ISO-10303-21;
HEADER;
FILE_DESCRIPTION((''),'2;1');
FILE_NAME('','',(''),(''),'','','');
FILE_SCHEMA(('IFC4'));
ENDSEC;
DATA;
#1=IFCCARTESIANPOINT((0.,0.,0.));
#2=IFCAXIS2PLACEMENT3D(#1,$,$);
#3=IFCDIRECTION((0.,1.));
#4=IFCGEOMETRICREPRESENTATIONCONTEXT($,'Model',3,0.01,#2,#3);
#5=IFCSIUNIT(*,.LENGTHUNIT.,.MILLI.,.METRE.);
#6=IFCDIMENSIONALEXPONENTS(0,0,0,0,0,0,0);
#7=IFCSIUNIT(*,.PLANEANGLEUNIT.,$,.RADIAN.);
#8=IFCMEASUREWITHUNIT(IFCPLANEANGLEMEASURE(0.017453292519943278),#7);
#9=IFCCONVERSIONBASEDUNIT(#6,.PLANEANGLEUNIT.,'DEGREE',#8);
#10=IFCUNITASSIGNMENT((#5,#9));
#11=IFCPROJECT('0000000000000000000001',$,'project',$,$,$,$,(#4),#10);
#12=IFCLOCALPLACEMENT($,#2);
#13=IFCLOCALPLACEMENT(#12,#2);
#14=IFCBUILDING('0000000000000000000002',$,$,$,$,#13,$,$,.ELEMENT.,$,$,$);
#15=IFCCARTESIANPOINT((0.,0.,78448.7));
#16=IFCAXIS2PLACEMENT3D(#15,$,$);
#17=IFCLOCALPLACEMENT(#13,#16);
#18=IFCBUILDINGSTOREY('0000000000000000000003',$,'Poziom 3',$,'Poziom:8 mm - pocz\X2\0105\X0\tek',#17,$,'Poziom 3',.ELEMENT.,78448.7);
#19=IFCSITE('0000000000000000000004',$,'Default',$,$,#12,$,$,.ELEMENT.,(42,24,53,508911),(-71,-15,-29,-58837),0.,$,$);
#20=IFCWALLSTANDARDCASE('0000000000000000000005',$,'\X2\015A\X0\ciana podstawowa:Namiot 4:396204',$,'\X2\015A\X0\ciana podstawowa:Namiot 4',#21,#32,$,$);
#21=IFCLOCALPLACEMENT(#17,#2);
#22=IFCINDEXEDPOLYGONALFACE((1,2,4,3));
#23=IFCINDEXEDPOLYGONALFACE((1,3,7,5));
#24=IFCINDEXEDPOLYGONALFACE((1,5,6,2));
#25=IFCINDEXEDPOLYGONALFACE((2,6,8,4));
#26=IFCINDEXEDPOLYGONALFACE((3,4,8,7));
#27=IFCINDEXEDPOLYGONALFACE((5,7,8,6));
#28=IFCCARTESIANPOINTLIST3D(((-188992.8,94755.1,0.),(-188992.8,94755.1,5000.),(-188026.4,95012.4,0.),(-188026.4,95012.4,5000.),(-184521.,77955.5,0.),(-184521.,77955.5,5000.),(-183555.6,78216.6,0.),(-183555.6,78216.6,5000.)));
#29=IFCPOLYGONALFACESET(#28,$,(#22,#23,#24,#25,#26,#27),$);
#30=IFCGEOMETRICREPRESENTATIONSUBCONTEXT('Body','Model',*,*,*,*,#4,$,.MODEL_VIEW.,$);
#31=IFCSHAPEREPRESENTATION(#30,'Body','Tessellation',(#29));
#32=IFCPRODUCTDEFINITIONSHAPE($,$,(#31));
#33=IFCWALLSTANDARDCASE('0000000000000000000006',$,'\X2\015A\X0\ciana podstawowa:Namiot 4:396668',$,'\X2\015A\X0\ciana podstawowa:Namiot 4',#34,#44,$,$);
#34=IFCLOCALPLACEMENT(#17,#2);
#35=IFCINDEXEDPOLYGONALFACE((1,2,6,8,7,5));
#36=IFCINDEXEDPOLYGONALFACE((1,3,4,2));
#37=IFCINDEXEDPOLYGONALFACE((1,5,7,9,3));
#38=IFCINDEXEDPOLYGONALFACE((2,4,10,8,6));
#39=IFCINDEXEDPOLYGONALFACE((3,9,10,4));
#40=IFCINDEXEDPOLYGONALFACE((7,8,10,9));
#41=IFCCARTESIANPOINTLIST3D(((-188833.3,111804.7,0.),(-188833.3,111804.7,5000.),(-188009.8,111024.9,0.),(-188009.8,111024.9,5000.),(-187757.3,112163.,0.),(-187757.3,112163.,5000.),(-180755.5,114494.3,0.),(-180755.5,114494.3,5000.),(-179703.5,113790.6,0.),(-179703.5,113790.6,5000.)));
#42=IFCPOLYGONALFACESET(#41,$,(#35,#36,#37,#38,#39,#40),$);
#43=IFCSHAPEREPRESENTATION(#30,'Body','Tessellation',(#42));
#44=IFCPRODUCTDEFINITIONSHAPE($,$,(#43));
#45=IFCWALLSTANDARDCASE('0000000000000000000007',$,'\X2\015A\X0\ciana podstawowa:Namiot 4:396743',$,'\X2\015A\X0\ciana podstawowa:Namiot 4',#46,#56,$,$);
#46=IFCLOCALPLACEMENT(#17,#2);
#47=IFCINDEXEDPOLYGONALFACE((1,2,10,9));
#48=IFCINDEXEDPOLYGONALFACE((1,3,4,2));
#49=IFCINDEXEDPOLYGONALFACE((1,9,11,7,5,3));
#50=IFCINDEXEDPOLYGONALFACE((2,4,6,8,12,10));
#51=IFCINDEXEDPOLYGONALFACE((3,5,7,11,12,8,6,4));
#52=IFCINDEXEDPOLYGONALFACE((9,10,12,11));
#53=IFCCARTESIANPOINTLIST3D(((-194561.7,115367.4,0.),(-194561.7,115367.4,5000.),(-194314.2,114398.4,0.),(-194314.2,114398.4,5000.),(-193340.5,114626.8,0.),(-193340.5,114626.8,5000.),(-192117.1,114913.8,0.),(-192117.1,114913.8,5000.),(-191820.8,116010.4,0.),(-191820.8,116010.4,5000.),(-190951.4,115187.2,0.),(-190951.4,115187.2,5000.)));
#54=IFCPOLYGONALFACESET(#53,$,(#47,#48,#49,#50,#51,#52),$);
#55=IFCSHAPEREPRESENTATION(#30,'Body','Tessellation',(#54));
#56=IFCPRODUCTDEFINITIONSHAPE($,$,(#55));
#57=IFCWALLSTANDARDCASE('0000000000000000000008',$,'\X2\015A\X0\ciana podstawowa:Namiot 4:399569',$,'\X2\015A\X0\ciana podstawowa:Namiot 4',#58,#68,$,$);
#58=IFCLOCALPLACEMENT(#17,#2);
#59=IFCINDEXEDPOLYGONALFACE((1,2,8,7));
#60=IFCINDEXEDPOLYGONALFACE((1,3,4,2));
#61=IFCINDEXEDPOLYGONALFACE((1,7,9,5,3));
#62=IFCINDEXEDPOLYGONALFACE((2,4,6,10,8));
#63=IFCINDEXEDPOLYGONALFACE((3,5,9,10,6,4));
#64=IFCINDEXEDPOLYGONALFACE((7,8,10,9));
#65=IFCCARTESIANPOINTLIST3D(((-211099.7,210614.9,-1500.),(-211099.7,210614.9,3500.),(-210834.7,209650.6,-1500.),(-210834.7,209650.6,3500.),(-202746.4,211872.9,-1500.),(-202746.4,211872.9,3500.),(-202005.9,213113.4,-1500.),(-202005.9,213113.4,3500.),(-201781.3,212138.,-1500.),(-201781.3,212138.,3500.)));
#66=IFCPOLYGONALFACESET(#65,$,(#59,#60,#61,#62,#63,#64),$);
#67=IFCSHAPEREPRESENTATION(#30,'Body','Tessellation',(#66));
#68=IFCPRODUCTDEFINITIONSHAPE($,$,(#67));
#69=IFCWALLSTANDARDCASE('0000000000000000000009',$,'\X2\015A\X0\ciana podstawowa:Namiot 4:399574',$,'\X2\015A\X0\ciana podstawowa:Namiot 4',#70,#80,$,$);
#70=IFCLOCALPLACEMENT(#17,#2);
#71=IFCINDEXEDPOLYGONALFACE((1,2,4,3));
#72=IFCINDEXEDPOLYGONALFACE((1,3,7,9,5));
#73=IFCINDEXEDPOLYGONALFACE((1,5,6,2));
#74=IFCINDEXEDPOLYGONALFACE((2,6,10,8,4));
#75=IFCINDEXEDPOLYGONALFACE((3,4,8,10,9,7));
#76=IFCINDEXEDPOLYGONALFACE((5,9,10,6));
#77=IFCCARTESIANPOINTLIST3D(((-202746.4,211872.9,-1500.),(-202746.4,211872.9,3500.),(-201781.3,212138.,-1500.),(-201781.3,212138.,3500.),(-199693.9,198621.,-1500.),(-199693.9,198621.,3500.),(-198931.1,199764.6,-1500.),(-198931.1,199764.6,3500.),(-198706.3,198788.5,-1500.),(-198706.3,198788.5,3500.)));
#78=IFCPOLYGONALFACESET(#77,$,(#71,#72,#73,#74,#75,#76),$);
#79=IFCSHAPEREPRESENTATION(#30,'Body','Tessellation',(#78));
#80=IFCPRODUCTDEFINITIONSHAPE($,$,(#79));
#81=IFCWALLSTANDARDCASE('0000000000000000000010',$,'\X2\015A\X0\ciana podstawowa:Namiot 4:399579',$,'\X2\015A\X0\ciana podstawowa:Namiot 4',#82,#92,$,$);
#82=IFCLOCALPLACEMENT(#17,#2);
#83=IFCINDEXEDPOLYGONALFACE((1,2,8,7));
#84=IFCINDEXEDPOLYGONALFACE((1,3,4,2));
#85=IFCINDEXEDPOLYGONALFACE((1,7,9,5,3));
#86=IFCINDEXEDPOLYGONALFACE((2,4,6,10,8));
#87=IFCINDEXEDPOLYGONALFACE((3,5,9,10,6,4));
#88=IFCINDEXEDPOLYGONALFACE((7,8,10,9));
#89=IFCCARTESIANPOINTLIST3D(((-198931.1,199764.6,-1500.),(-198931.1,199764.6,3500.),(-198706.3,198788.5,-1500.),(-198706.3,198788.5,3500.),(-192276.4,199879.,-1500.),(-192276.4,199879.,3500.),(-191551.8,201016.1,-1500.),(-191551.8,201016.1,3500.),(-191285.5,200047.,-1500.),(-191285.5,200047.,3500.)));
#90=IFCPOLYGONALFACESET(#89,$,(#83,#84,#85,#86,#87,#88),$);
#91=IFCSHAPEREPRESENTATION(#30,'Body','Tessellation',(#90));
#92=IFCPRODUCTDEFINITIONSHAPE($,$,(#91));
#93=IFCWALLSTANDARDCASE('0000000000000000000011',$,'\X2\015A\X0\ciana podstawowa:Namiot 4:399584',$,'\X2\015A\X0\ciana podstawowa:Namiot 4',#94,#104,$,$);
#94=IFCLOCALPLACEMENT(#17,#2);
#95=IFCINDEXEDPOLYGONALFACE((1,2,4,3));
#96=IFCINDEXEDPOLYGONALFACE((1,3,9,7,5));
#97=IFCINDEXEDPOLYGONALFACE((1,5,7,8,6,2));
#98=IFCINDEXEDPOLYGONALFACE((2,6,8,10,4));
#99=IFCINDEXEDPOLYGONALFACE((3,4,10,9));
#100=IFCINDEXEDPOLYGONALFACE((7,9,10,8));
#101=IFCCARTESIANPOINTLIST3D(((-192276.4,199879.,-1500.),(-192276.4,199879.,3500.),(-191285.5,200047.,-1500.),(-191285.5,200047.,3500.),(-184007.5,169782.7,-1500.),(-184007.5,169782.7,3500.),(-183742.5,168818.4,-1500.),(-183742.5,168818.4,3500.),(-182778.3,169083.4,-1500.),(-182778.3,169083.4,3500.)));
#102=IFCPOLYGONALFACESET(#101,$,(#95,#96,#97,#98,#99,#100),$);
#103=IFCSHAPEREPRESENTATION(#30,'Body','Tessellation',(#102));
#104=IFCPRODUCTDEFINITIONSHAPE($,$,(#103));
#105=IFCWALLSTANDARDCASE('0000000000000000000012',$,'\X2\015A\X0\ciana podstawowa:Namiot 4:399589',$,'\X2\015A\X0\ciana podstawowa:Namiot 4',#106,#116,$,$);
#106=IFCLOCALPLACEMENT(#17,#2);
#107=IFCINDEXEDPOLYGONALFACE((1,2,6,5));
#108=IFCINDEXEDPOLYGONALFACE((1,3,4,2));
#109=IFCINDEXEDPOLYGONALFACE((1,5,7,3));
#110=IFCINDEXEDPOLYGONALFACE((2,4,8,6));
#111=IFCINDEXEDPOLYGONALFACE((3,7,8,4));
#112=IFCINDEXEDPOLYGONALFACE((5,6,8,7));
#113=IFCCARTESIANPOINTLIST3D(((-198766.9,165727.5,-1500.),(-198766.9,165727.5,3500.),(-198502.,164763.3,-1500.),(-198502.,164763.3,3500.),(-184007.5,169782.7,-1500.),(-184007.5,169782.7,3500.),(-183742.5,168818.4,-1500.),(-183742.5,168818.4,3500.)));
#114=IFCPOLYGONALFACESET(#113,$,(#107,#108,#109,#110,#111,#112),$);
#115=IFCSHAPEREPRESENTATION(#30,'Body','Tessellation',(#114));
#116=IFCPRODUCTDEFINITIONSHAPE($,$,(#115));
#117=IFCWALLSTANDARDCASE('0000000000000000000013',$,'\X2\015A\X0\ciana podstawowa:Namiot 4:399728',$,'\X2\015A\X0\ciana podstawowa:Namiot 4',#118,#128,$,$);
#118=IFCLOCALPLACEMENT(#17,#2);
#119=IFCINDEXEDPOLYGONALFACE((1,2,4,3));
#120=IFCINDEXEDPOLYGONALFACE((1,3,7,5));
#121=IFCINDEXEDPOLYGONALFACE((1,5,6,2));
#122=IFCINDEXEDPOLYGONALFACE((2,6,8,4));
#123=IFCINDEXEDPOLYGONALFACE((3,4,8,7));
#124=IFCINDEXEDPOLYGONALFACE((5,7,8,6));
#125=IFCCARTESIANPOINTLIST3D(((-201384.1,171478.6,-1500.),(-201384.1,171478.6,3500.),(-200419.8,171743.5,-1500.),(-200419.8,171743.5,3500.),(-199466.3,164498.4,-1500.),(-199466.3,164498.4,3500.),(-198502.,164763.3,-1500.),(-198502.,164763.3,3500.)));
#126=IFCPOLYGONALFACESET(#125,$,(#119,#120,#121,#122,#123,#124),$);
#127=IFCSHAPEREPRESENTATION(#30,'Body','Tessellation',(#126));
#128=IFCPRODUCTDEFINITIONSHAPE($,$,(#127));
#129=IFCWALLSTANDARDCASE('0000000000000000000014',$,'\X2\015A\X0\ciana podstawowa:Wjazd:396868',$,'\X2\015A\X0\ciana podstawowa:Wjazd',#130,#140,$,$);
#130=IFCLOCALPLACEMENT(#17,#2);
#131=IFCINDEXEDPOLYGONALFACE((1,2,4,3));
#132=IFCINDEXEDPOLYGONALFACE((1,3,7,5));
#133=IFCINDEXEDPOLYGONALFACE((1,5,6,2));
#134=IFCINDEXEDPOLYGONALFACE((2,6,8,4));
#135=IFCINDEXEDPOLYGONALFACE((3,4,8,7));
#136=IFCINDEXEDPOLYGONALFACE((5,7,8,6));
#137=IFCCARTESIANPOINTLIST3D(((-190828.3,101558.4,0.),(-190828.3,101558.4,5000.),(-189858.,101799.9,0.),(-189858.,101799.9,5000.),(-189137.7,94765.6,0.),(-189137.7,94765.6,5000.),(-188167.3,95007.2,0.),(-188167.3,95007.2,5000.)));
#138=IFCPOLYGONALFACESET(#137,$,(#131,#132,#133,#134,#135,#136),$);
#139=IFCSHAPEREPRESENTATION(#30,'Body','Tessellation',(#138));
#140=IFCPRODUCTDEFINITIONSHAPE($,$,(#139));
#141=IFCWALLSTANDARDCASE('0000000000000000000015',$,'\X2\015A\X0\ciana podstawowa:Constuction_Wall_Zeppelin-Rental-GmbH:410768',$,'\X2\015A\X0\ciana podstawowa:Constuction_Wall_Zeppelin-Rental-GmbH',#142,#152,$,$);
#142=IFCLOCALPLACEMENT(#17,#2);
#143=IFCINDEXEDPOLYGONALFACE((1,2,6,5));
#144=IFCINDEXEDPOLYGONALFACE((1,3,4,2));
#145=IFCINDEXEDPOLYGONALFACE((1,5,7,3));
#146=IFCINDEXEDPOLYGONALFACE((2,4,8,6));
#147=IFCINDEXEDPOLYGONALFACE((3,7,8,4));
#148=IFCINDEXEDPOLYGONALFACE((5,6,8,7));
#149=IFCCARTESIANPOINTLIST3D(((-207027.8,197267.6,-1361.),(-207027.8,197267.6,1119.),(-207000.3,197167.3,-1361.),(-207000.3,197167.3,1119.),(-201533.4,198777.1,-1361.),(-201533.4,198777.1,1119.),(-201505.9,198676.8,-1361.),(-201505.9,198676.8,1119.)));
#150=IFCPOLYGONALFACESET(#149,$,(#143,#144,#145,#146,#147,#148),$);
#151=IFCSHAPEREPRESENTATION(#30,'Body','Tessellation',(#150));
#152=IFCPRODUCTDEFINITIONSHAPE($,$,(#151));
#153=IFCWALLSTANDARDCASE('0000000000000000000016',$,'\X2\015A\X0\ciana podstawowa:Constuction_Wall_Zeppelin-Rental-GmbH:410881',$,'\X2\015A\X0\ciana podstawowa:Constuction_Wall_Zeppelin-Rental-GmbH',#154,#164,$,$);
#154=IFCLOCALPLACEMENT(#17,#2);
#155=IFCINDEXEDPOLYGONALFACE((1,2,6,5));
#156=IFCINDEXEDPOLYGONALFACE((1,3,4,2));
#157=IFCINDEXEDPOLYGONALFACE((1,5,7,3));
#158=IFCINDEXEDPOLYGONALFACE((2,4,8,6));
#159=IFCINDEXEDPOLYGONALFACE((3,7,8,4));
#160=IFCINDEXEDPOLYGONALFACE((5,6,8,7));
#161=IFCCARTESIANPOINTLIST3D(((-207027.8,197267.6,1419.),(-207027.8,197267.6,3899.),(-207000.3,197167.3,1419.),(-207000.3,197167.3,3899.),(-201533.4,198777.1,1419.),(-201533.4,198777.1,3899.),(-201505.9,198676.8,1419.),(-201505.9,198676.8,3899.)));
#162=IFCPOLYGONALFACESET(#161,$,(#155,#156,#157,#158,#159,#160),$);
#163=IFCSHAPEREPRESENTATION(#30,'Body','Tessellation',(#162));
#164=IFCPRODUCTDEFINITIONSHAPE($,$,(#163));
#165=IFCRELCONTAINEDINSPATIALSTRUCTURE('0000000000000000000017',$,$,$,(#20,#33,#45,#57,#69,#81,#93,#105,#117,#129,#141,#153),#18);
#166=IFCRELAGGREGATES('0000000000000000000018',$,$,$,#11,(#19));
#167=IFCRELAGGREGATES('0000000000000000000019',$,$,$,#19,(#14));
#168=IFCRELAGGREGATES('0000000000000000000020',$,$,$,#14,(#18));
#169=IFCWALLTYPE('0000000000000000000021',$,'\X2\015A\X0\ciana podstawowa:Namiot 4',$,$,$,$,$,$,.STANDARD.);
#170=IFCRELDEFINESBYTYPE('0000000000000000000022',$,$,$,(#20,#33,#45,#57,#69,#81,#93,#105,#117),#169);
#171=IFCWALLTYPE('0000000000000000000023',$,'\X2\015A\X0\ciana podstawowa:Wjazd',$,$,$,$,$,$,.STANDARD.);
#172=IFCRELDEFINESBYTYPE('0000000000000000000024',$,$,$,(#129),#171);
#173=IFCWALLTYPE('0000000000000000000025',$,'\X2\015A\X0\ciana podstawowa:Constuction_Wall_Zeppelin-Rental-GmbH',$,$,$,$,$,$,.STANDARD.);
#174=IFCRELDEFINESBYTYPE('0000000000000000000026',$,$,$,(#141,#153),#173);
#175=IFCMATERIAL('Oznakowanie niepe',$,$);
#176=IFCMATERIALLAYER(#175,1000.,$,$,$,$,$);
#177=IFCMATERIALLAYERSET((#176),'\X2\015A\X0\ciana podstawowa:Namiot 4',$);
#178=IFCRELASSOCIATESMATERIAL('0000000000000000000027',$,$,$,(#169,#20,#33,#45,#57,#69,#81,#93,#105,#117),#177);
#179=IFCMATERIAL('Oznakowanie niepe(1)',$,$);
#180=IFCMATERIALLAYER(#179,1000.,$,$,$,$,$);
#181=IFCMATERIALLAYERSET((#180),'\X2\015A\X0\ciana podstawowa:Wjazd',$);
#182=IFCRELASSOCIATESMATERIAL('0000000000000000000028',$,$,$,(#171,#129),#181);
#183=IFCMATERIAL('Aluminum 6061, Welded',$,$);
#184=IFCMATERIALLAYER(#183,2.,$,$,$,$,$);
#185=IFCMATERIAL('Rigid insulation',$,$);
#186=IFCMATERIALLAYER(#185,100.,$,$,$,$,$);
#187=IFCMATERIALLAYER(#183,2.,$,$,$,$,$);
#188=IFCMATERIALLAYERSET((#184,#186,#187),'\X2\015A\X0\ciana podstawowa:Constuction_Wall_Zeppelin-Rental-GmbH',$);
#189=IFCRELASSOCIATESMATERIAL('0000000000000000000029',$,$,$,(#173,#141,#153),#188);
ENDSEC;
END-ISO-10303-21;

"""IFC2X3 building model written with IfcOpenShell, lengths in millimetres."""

from ifc_helpers import new_model, entity, si_unit, converted_unit, direction, frame, frame_2d, origin, place, context, subcontext, project, spatial, polyline, rectangle, outline, extrude, material, layer, layer_set, layer_usage, type_object, element, save


model = new_model("IFC2X3")

# Units and contexts
model_context = context("Model", 3, precision=0.01, world=origin(), true_north=direction((0.0, 1.0)))
body_context = subcontext(model_context, "Body", "Model", "MODEL_VIEW")
ifc_project = project(units=[si_unit("LENGTHUNIT", "METRE", prefix="MILLI"), converted_unit("PLANEANGLEUNIT", "DEGREE", entity("IfcPlaneAngleMeasure", 0.017453292519943278), si_unit("PLANEANGLEUNIT", "RADIAN"), dimensions=[0, 0, 0, 0, 0, 0, 0])], contexts=[model_context])

# Site, building, storey
site_placement = place(None, origin())
site = spatial("IfcSite", under=ifc_project, at=site_placement, Name="Default", CompositionType="ELEMENT", RefLatitude=(42, 24, 53, 508911), RefLongitude=(-71, -15, -29, -58837), RefElevation=0.0)
building_placement = place(site_placement, origin())
building = spatial("IfcBuilding", under=site, at=building_placement, CompositionType="ELEMENT")
storey_placement = place(building_placement, frame((0.0, 0.0, 78448.7)))
storey = spatial("IfcBuildingStorey", under=building, at=storey_placement, Name="Poziom 3", ObjectType="Poziom:8 mm - początek", LongName="Poziom 3", CompositionType="ELEMENT", Elevation=78448.7)

# Walls
ifc_material_1 = material(Name="Oznakowanie niepe")
ifc_layer_1 = layer(ifc_material_1, 1000.0)
ifc_layer_set_1 = layer_set([ifc_layer_1], Name="Ściana podstawowa:Namiot 4")
ifc_layer_usage_1 = layer_usage(ifc_layer_set_1, "AXIS2", "NEGATIVE", 500.0)
wall_type_1 = type_object("IfcWallType", Name="Ściana podstawowa:Namiot 4", PredefinedType="STANDARD", material=ifc_layer_set_1)
wall_1_placement = place(storey_placement, frame((-188509.6, 94883.7, 0.0), z_axis=(0.0, 0.0, 1.0), x_axis=(0.257227, -0.966351, 0.0)))
element("IfcWallStandardCase", 1, at=wall_1_placement, inside=storey, type_object=wall_type_1, material=ifc_layer_usage_1, Name="Ściana podstawowa:Namiot 4:396204", ObjectType="Ściana podstawowa:Namiot 4", context=body_context, shape_type="SweptSolid", body=[
    extrude(outline(polyline([(17384.6, -500.0), (17380.6, 500.0), (0.0, 500.0), (0.0, -500.0), (17384.6, -500.0)])), origin(), (0.0, 0.0, 1.0), 5000.0),
])
ifc_layer_usage_2 = layer_usage(ifc_layer_set_1, "AXIS2", "NEGATIVE", 500.0)
wall_2_placement = place(storey_placement, frame((-179861.5, 114265.0, 0.0), z_axis=(0.0, 0.0, 1.0), x_axis=(-0.948789, -0.315912, 0.0)))
element("IfcWallStandardCase", 2, at=wall_2_placement, inside=storey, type_object=wall_type_1, material=ifc_layer_usage_2, Name="Ściana podstawowa:Namiot 4:396668", ObjectType="Ściana podstawowa:Namiot 4", context=body_context, shape_type="SweptSolid", body=[
    extrude(outline(polyline([(9289.7, -500.0), (8754.6, 500.0), (0.0, 500.0), (775.8, -500.0), (8155.5, -500.0), (9289.7, -500.0)])), origin(), (0.0, 0.0, 1.0), 5000.0),
])
ifc_layer_usage_3 = layer_usage(ifc_layer_set_1, "AXIS2", "NEGATIVE", 500.0)
wall_3_placement = place(storey_placement, frame((-191065.6, 115674.0, 0.0), z_axis=(0.0, 0.0, 1.0), x_axis=(-0.97357, -0.228388, 0.0)))
element("IfcWallStandardCase", 3, at=wall_3_placement, inside=storey, type_object=wall_type_1, material=ifc_layer_usage_3, Name="Ściana podstawowa:Namiot 4:396743", ObjectType="Ściana podstawowa:Namiot 4", context=body_context, shape_type="SweptSolid", body=[
    extrude(outline(polyline([(3473.7, -500.0), (3454.1, 500.0), (2453.9, 500.0), (1197.3, 500.0), (0.0, 500.0), (658.4, -500.0), (3473.7, -500.0)])), origin(), (0.0, 0.0, 1.0), 5000.0),
])
ifc_layer_usage_4 = layer_usage(ifc_layer_set_1, "AXIS2", "NEGATIVE", 500.0)
wall_4_placement = place(storey_placement, frame((-201873.5, 212631.2, -1500.0), z_axis=(0.0, 0.0, 1.0), x_axis=(-0.964267, -0.264931, 0.0)))
element("IfcWallStandardCase", 4, at=wall_4_placement, inside=storey, type_object=wall_type_1, material=ifc_layer_usage_4, Name="Ściana podstawowa:Namiot 4:399569", ObjectType="Ściana podstawowa:Namiot 4", context=body_context, shape_type="SweptSolid", body=[
    extrude(outline(polyline([(9430.7, -500.0), (9430.7, 500.0), (1042.6, 500.0), (41.8, 500.0), (0.0, -500.0), (9430.7, -500.0)])), origin(), (0.0, 0.0, 1.0), 5000.0),
])
ifc_layer_usage_5 = layer_usage(ifc_layer_set_1, "AXIS2", "NEGATIVE", 500.0)
wall_5_placement = place(storey_placement, frame((-199193.5, 198676.2, -1500.0), z_axis=(0.0, 0.0, 1.0), x_axis=(-0.224467, 0.974482, 0.0)))
element("IfcWallStandardCase", 5, at=wall_5_placement, inside=storey, type_object=wall_type_1, material=ifc_layer_usage_5, Name="Ściana podstawowa:Namiot 4:399574", ObjectType="Ściana podstawowa:Namiot 4", context=body_context, shape_type="SweptSolid", body=[
    extrude(outline(polyline([(13699.1, -500.0), (13657.4, 500.0), (58.5, 500.0), (0.0, -500.0), (1001.7, -500.0), (13699.1, -500.0)])), origin(), (0.0, 0.0, 1.0), 5000.0),
])
ifc_layer_usage_6 = layer_usage(ifc_layer_set_1, "AXIS2", "NEGATIVE", 500.0)
wall_6_placement = place(storey_placement, frame((-191369.1, 200540.0, -1500.0), z_axis=(0.0, 0.0, 1.0), x_axis=(-0.985921, -0.167211, 0.0)))
element("IfcWallStandardCase", 6, at=wall_6_placement, inside=storey, type_object=wall_type_1, material=ifc_layer_usage_6, Name="Ściana podstawowa:Namiot 4:399579", ObjectType="Ściana podstawowa:Namiot 4", context=body_context, shape_type="SweptSolid", body=[
    extrude(outline(polyline([(7585.2, -500.0), (7526.7, 500.0), (1005.0, 500.0), (0.0, 500.0), (100.5, -500.0), (7585.2, -500.0)])), origin(), (0.0, 0.0, 1.0), 5000.0),
])
ifc_layer_usage_7 = layer_usage(ifc_layer_set_1, "AXIS2", "NEGATIVE", 500.0)
wall_7_placement = place(storey_placement, frame((-183260.4, 168950.9, -1500.0), z_axis=(0.0, 0.0, 1.0), x_axis=(-0.264931, 0.964267, 0.0)))
element("IfcWallStandardCase", 7, at=wall_7_placement, inside=storey, type_object=wall_type_1, material=ifc_layer_usage_7, Name="Ściana podstawowa:Namiot 4:399584", ObjectType="Ściana podstawowa:Namiot 4", context=body_context, shape_type="SweptSolid", body=[
    extrude(outline(polyline([(32111.1, -500.0), (32211.6, 500.0), (1000.0, 500.0), (0.0, 500.0), (0.0, -500.0), (32111.1, -500.0)])), origin(), (0.0, 0.0, 1.0), 5000.0),
])
ifc_layer_usage_8 = layer_usage(ifc_layer_set_1, "AXIS2", "NEGATIVE", 500.0)
wall_8_placement = place(storey_placement, frame((-198634.5, 165245.4, -1500.0), z_axis=(0.0, 0.0, 1.0), x_axis=(0.964267, 0.264931, 0.0)))
element("IfcWallStandardCase", 8, at=wall_8_placement, inside=storey, type_object=wall_type_1, material=ifc_layer_usage_8, Name="Ściana podstawowa:Namiot 4:399589", ObjectType="Ściana podstawowa:Namiot 4", context=body_context, shape_type="SweptSolid", body=[
    extrude(rectangle(XDim=15306.4, YDim=1000.0, at=frame_2d((7653.2, 0.0), x_axis=(-1.0, 0.0))), origin(), (0.0, 0.0, 1.0), 5000.0),
])
ifc_layer_usage_9 = layer_usage(ifc_layer_set_1, "AXIS2", "NEGATIVE", 500.0)
wall_9_placement = place(storey_placement, frame((-200902.0, 171611.0, -1500.0), z_axis=(0.0, 0.0, 1.0), x_axis=(0.264931, -0.964267, 0.0)))
element("IfcWallStandardCase", 9, at=wall_9_placement, inside=storey, type_object=wall_type_1, material=ifc_layer_usage_9, Name="Ściana podstawowa:Namiot 4:399728", ObjectType="Ściana podstawowa:Namiot 4", context=body_context, shape_type="SweptSolid", body=[
    extrude(rectangle(XDim=7238.9, YDim=1000.0, at=frame_2d((3619.4, 0.0), x_axis=(-1.0, 0.0))), origin(), (0.0, 0.0, 1.0), 5000.0),
])
ifc_material_2 = material(Name="Oznakowanie niepe(1)")
ifc_layer_2 = layer(ifc_material_2, 1000.0)
ifc_layer_set_2 = layer_set([ifc_layer_2], Name="Ściana podstawowa:Wjazd")
ifc_layer_usage_10 = layer_usage(ifc_layer_set_2, "AXIS2", "NEGATIVE", 500.0)
wall_type_2 = type_object("IfcWallType", Name="Ściana podstawowa:Wjazd", PredefinedType="STANDARD", material=ifc_layer_set_2)
wall_10_placement = place(storey_placement, frame((-190343.2, 101679.2, 0.0), z_axis=(0.0, 0.0, 1.0), x_axis=(0.241526, -0.970394, 0.0)))
element("IfcWallStandardCase", 10, at=wall_10_placement, inside=storey, type_object=wall_type_2, material=ifc_layer_usage_10, Name="Ściana podstawowa:Wjazd:396868", ObjectType="Ściana podstawowa:Wjazd", context=body_context, shape_type="SweptSolid", body=[
    extrude(rectangle(XDim=7000.0, YDim=1000.0, at=frame_2d((3500.0, 0.0), x_axis=(-1.0, 0.0))), origin(), (0.0, 0.0, 1.0), 5000.0),
])
ifc_material_3 = material(Name="Aluminum 6061, Welded")
ifc_layer_3 = layer(ifc_material_3, 2.0)
ifc_material_4 = material(Name="Rigid insulation")
ifc_layer_4 = layer(ifc_material_4, 100.0)
ifc_layer_5 = layer(ifc_material_3, 2.0)
ifc_layer_set_3 = layer_set([ifc_layer_3, ifc_layer_4, ifc_layer_5], Name="Ściana podstawowa:Constuction_Wall_Zeppelin-Rental-GmbH")
ifc_layer_usage_11 = layer_usage(ifc_layer_set_3, "AXIS2", "NEGATIVE", 52.0)
wall_type_3 = type_object("IfcWallType", Name="Ściana podstawowa:Constuction_Wall_Zeppelin-Rental-GmbH", PredefinedType="STANDARD", material=ifc_layer_set_3)
wall_11_placement = place(storey_placement, frame((-201519.6, 198727.0, -1361.0), z_axis=(0.0, 0.0, 1.0), x_axis=(-0.964267, -0.264931, 0.0)))
element("IfcWallStandardCase", 11, at=wall_11_placement, inside=storey, type_object=wall_type_3, material=ifc_layer_usage_11, Name="Ściana podstawowa:Constuction_Wall_Zeppelin-Rental-GmbH:410768", ObjectType="Ściana podstawowa:Constuction_Wall_Zeppelin-Rental-GmbH", context=body_context, shape_type="SweptSolid", body=[
    extrude(rectangle(XDim=5698.0, YDim=104.0, at=frame_2d((2849.0, 0.0), x_axis=(-1.0, 0.0))), origin(), (0.0, 0.0, 1.0), 2480.0),
])
ifc_layer_usage_12 = layer_usage(ifc_layer_set_3, "AXIS2", "NEGATIVE", 52.0)
wall_12_placement = place(storey_placement, frame((-201519.6, 198727.0, 1419.0), z_axis=(0.0, 0.0, 1.0), x_axis=(-0.964267, -0.264931, 0.0)))
element("IfcWallStandardCase", 12, at=wall_12_placement, inside=storey, type_object=wall_type_3, material=ifc_layer_usage_12, Name="Ściana podstawowa:Constuction_Wall_Zeppelin-Rental-GmbH:410881", ObjectType="Ściana podstawowa:Constuction_Wall_Zeppelin-Rental-GmbH", context=body_context, shape_type="SweptSolid", body=[
    extrude(rectangle(XDim=5698.0, YDim=104.0, at=frame_2d((2849.0, 0.0), x_axis=(-1.0, 0.0))), origin(), (0.0, 0.0, 1.0), 2480.0),
])

save(model, "model.ifc")
